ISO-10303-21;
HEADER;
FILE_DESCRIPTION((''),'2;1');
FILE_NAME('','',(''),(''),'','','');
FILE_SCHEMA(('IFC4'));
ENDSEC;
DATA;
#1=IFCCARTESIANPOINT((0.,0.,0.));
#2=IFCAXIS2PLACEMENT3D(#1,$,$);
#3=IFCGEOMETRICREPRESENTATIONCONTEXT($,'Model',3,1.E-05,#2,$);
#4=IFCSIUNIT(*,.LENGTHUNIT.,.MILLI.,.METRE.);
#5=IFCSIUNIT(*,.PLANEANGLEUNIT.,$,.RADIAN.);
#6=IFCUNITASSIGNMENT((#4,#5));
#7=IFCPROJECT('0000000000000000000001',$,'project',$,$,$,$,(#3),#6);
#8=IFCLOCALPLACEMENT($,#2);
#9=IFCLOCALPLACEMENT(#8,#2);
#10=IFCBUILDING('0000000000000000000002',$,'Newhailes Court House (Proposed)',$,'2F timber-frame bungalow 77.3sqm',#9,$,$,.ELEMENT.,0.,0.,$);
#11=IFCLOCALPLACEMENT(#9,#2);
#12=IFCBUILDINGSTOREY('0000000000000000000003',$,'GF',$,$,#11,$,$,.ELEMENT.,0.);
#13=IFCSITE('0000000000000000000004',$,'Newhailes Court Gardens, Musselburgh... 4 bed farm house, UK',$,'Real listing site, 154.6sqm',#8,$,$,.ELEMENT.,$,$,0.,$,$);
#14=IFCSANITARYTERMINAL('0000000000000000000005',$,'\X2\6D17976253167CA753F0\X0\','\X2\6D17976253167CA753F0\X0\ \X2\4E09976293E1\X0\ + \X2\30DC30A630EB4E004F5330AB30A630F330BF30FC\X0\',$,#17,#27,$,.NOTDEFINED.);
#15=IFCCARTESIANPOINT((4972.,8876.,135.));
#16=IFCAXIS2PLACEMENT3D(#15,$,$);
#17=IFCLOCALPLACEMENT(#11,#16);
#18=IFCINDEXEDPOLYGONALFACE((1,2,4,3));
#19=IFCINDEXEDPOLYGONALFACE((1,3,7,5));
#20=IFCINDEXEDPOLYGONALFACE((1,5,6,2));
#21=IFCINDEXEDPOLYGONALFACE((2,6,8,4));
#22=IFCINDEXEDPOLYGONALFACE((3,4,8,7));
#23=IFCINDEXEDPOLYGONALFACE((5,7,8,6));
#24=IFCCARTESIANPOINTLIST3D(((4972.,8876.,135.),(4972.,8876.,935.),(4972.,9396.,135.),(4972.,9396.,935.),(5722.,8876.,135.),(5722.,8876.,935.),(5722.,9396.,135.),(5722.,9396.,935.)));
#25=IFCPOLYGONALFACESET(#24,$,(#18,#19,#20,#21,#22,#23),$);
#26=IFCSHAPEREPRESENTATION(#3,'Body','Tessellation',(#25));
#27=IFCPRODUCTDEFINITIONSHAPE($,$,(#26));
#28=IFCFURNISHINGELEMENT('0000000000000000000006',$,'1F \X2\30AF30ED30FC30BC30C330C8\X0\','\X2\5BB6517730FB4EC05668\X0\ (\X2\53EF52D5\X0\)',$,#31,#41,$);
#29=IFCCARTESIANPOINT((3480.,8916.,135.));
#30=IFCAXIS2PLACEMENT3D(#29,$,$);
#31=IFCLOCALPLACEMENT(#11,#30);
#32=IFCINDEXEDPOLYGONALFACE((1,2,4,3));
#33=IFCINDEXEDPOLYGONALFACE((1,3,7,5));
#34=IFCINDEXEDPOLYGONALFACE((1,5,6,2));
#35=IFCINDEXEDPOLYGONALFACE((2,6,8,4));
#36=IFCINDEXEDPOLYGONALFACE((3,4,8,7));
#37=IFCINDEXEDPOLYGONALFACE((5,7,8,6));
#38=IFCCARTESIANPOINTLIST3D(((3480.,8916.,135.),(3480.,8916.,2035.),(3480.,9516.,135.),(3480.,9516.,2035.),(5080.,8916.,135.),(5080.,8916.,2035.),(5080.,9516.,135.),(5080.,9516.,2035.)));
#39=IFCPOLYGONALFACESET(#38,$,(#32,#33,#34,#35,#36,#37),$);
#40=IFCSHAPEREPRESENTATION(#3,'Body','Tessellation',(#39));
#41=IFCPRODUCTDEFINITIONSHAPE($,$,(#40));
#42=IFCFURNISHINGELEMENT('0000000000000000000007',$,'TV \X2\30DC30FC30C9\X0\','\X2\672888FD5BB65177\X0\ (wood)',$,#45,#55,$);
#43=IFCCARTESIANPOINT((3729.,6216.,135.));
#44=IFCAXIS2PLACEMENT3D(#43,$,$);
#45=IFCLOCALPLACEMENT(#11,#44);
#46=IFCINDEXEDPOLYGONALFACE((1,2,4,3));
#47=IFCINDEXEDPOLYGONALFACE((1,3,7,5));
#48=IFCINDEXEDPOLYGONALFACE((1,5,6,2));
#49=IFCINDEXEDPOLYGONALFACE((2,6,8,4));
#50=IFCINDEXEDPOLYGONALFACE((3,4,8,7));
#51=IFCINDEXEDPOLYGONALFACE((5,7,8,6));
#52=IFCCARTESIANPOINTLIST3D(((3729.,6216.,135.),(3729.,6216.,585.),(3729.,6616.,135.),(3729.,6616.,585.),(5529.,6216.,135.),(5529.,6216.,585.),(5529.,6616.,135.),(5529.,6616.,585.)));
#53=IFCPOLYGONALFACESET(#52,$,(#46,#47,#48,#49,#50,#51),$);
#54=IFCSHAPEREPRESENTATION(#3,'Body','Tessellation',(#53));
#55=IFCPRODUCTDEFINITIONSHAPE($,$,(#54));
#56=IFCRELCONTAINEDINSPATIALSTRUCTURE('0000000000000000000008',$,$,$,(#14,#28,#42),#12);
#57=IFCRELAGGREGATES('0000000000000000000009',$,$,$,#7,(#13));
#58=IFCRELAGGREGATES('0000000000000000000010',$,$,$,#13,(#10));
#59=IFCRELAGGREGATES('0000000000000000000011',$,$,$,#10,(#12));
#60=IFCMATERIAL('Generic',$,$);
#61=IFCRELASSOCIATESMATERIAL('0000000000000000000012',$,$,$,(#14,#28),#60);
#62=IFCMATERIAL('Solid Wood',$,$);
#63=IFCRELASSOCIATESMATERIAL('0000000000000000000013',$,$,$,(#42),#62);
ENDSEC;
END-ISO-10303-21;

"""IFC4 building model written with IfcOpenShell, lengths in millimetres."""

from ifc_helpers import new_model, si_unit, frame, frame_2d, origin, place, context, project, spatial, rectangle, extrude, material, element, save


model = new_model("IFC4")

# Units and contexts
model_context = context("Model", 3, precision=1e-05, world=origin())
ifc_project = project(units=[si_unit("LENGTHUNIT", "METRE", prefix="MILLI"), si_unit("PLANEANGLEUNIT", "RADIAN")], contexts=[model_context])

# Site, building, storey
site_placement = place(None, origin())
site = spatial("IfcSite", under=ifc_project, at=site_placement, Name="Newhailes Court Gardens, Musselburgh... 4 bed farm house, UK", ObjectType="Real listing site, 154.6sqm", CompositionType="ELEMENT", RefElevation=0.0)
building_placement = place(site_placement, origin())
building = spatial("IfcBuilding", under=site, at=building_placement, Name="Newhailes Court House (Proposed)", ObjectType="2F timber-frame bungalow 77.3sqm", CompositionType="ELEMENT", ElevationOfRefHeight=0.0, ElevationOfTerrain=0.0)
storey_placement = place(building_placement, origin())
storey = spatial("IfcBuildingStorey", under=building, at=storey_placement, Name="GF", CompositionType="ELEMENT", Elevation=0.0)

# Shared definitions
ifc_material_1 = material(Name="Solid Wood")

# Shared definitions
ifc_material_2 = material(Name="Generic")

# Sanitary terminal
sanitary_terminal_1_placement = place(storey_placement, frame((4972.0, 8876.0, 135.0)))
element("IfcSanitaryTerminal", 1, at=sanitary_terminal_1_placement, inside=storey, material=ifc_material_2, Name="洗面化粧台", Description="洗面化粧台 三面鏡 + ボウル一体カウンター", PredefinedType="NOTDEFINED", context=model_context, shape_type="SweptSolid", body=[
    extrude(rectangle(XDim=750.0, YDim=520.0, at=frame_2d((375.0, 260.0))), frame((4972.0, 8876.0, 135.0)), (0.0, 0.0, 1.0), 800.0),
])

# Furnishing elements
furnishing_1_placement = place(storey_placement, frame((3480.0, 8916.0, 135.0)))
element("IfcFurnishingElement", 2, at=furnishing_1_placement, inside=storey, material=ifc_material_2, Name="1F クローゼット", Description="家具・什器 (可動)", context=model_context, shape_type="SweptSolid", body=[
    extrude(rectangle(XDim=1600.0, YDim=600.0, at=frame_2d((800.0, 300.0))), frame((3480.0, 8916.0, 135.0)), (0.0, 0.0, 1.0), 1900.0),
])
furnishing_2_placement = place(storey_placement, frame((3729.0, 6216.0, 135.0)))
element("IfcFurnishingElement", 3, at=furnishing_2_placement, inside=storey, material=ifc_material_1, Name="TV ボード", Description="木製家具 (wood)", context=model_context, shape_type="SweptSolid", body=[
    extrude(rectangle(XDim=1800.0, YDim=400.0, at=frame_2d((900.0, 200.0))), frame((3729.0, 6216.0, 135.0)), (0.0, 0.0, 1.0), 450.0),
])

save(model, "model.ifc")
